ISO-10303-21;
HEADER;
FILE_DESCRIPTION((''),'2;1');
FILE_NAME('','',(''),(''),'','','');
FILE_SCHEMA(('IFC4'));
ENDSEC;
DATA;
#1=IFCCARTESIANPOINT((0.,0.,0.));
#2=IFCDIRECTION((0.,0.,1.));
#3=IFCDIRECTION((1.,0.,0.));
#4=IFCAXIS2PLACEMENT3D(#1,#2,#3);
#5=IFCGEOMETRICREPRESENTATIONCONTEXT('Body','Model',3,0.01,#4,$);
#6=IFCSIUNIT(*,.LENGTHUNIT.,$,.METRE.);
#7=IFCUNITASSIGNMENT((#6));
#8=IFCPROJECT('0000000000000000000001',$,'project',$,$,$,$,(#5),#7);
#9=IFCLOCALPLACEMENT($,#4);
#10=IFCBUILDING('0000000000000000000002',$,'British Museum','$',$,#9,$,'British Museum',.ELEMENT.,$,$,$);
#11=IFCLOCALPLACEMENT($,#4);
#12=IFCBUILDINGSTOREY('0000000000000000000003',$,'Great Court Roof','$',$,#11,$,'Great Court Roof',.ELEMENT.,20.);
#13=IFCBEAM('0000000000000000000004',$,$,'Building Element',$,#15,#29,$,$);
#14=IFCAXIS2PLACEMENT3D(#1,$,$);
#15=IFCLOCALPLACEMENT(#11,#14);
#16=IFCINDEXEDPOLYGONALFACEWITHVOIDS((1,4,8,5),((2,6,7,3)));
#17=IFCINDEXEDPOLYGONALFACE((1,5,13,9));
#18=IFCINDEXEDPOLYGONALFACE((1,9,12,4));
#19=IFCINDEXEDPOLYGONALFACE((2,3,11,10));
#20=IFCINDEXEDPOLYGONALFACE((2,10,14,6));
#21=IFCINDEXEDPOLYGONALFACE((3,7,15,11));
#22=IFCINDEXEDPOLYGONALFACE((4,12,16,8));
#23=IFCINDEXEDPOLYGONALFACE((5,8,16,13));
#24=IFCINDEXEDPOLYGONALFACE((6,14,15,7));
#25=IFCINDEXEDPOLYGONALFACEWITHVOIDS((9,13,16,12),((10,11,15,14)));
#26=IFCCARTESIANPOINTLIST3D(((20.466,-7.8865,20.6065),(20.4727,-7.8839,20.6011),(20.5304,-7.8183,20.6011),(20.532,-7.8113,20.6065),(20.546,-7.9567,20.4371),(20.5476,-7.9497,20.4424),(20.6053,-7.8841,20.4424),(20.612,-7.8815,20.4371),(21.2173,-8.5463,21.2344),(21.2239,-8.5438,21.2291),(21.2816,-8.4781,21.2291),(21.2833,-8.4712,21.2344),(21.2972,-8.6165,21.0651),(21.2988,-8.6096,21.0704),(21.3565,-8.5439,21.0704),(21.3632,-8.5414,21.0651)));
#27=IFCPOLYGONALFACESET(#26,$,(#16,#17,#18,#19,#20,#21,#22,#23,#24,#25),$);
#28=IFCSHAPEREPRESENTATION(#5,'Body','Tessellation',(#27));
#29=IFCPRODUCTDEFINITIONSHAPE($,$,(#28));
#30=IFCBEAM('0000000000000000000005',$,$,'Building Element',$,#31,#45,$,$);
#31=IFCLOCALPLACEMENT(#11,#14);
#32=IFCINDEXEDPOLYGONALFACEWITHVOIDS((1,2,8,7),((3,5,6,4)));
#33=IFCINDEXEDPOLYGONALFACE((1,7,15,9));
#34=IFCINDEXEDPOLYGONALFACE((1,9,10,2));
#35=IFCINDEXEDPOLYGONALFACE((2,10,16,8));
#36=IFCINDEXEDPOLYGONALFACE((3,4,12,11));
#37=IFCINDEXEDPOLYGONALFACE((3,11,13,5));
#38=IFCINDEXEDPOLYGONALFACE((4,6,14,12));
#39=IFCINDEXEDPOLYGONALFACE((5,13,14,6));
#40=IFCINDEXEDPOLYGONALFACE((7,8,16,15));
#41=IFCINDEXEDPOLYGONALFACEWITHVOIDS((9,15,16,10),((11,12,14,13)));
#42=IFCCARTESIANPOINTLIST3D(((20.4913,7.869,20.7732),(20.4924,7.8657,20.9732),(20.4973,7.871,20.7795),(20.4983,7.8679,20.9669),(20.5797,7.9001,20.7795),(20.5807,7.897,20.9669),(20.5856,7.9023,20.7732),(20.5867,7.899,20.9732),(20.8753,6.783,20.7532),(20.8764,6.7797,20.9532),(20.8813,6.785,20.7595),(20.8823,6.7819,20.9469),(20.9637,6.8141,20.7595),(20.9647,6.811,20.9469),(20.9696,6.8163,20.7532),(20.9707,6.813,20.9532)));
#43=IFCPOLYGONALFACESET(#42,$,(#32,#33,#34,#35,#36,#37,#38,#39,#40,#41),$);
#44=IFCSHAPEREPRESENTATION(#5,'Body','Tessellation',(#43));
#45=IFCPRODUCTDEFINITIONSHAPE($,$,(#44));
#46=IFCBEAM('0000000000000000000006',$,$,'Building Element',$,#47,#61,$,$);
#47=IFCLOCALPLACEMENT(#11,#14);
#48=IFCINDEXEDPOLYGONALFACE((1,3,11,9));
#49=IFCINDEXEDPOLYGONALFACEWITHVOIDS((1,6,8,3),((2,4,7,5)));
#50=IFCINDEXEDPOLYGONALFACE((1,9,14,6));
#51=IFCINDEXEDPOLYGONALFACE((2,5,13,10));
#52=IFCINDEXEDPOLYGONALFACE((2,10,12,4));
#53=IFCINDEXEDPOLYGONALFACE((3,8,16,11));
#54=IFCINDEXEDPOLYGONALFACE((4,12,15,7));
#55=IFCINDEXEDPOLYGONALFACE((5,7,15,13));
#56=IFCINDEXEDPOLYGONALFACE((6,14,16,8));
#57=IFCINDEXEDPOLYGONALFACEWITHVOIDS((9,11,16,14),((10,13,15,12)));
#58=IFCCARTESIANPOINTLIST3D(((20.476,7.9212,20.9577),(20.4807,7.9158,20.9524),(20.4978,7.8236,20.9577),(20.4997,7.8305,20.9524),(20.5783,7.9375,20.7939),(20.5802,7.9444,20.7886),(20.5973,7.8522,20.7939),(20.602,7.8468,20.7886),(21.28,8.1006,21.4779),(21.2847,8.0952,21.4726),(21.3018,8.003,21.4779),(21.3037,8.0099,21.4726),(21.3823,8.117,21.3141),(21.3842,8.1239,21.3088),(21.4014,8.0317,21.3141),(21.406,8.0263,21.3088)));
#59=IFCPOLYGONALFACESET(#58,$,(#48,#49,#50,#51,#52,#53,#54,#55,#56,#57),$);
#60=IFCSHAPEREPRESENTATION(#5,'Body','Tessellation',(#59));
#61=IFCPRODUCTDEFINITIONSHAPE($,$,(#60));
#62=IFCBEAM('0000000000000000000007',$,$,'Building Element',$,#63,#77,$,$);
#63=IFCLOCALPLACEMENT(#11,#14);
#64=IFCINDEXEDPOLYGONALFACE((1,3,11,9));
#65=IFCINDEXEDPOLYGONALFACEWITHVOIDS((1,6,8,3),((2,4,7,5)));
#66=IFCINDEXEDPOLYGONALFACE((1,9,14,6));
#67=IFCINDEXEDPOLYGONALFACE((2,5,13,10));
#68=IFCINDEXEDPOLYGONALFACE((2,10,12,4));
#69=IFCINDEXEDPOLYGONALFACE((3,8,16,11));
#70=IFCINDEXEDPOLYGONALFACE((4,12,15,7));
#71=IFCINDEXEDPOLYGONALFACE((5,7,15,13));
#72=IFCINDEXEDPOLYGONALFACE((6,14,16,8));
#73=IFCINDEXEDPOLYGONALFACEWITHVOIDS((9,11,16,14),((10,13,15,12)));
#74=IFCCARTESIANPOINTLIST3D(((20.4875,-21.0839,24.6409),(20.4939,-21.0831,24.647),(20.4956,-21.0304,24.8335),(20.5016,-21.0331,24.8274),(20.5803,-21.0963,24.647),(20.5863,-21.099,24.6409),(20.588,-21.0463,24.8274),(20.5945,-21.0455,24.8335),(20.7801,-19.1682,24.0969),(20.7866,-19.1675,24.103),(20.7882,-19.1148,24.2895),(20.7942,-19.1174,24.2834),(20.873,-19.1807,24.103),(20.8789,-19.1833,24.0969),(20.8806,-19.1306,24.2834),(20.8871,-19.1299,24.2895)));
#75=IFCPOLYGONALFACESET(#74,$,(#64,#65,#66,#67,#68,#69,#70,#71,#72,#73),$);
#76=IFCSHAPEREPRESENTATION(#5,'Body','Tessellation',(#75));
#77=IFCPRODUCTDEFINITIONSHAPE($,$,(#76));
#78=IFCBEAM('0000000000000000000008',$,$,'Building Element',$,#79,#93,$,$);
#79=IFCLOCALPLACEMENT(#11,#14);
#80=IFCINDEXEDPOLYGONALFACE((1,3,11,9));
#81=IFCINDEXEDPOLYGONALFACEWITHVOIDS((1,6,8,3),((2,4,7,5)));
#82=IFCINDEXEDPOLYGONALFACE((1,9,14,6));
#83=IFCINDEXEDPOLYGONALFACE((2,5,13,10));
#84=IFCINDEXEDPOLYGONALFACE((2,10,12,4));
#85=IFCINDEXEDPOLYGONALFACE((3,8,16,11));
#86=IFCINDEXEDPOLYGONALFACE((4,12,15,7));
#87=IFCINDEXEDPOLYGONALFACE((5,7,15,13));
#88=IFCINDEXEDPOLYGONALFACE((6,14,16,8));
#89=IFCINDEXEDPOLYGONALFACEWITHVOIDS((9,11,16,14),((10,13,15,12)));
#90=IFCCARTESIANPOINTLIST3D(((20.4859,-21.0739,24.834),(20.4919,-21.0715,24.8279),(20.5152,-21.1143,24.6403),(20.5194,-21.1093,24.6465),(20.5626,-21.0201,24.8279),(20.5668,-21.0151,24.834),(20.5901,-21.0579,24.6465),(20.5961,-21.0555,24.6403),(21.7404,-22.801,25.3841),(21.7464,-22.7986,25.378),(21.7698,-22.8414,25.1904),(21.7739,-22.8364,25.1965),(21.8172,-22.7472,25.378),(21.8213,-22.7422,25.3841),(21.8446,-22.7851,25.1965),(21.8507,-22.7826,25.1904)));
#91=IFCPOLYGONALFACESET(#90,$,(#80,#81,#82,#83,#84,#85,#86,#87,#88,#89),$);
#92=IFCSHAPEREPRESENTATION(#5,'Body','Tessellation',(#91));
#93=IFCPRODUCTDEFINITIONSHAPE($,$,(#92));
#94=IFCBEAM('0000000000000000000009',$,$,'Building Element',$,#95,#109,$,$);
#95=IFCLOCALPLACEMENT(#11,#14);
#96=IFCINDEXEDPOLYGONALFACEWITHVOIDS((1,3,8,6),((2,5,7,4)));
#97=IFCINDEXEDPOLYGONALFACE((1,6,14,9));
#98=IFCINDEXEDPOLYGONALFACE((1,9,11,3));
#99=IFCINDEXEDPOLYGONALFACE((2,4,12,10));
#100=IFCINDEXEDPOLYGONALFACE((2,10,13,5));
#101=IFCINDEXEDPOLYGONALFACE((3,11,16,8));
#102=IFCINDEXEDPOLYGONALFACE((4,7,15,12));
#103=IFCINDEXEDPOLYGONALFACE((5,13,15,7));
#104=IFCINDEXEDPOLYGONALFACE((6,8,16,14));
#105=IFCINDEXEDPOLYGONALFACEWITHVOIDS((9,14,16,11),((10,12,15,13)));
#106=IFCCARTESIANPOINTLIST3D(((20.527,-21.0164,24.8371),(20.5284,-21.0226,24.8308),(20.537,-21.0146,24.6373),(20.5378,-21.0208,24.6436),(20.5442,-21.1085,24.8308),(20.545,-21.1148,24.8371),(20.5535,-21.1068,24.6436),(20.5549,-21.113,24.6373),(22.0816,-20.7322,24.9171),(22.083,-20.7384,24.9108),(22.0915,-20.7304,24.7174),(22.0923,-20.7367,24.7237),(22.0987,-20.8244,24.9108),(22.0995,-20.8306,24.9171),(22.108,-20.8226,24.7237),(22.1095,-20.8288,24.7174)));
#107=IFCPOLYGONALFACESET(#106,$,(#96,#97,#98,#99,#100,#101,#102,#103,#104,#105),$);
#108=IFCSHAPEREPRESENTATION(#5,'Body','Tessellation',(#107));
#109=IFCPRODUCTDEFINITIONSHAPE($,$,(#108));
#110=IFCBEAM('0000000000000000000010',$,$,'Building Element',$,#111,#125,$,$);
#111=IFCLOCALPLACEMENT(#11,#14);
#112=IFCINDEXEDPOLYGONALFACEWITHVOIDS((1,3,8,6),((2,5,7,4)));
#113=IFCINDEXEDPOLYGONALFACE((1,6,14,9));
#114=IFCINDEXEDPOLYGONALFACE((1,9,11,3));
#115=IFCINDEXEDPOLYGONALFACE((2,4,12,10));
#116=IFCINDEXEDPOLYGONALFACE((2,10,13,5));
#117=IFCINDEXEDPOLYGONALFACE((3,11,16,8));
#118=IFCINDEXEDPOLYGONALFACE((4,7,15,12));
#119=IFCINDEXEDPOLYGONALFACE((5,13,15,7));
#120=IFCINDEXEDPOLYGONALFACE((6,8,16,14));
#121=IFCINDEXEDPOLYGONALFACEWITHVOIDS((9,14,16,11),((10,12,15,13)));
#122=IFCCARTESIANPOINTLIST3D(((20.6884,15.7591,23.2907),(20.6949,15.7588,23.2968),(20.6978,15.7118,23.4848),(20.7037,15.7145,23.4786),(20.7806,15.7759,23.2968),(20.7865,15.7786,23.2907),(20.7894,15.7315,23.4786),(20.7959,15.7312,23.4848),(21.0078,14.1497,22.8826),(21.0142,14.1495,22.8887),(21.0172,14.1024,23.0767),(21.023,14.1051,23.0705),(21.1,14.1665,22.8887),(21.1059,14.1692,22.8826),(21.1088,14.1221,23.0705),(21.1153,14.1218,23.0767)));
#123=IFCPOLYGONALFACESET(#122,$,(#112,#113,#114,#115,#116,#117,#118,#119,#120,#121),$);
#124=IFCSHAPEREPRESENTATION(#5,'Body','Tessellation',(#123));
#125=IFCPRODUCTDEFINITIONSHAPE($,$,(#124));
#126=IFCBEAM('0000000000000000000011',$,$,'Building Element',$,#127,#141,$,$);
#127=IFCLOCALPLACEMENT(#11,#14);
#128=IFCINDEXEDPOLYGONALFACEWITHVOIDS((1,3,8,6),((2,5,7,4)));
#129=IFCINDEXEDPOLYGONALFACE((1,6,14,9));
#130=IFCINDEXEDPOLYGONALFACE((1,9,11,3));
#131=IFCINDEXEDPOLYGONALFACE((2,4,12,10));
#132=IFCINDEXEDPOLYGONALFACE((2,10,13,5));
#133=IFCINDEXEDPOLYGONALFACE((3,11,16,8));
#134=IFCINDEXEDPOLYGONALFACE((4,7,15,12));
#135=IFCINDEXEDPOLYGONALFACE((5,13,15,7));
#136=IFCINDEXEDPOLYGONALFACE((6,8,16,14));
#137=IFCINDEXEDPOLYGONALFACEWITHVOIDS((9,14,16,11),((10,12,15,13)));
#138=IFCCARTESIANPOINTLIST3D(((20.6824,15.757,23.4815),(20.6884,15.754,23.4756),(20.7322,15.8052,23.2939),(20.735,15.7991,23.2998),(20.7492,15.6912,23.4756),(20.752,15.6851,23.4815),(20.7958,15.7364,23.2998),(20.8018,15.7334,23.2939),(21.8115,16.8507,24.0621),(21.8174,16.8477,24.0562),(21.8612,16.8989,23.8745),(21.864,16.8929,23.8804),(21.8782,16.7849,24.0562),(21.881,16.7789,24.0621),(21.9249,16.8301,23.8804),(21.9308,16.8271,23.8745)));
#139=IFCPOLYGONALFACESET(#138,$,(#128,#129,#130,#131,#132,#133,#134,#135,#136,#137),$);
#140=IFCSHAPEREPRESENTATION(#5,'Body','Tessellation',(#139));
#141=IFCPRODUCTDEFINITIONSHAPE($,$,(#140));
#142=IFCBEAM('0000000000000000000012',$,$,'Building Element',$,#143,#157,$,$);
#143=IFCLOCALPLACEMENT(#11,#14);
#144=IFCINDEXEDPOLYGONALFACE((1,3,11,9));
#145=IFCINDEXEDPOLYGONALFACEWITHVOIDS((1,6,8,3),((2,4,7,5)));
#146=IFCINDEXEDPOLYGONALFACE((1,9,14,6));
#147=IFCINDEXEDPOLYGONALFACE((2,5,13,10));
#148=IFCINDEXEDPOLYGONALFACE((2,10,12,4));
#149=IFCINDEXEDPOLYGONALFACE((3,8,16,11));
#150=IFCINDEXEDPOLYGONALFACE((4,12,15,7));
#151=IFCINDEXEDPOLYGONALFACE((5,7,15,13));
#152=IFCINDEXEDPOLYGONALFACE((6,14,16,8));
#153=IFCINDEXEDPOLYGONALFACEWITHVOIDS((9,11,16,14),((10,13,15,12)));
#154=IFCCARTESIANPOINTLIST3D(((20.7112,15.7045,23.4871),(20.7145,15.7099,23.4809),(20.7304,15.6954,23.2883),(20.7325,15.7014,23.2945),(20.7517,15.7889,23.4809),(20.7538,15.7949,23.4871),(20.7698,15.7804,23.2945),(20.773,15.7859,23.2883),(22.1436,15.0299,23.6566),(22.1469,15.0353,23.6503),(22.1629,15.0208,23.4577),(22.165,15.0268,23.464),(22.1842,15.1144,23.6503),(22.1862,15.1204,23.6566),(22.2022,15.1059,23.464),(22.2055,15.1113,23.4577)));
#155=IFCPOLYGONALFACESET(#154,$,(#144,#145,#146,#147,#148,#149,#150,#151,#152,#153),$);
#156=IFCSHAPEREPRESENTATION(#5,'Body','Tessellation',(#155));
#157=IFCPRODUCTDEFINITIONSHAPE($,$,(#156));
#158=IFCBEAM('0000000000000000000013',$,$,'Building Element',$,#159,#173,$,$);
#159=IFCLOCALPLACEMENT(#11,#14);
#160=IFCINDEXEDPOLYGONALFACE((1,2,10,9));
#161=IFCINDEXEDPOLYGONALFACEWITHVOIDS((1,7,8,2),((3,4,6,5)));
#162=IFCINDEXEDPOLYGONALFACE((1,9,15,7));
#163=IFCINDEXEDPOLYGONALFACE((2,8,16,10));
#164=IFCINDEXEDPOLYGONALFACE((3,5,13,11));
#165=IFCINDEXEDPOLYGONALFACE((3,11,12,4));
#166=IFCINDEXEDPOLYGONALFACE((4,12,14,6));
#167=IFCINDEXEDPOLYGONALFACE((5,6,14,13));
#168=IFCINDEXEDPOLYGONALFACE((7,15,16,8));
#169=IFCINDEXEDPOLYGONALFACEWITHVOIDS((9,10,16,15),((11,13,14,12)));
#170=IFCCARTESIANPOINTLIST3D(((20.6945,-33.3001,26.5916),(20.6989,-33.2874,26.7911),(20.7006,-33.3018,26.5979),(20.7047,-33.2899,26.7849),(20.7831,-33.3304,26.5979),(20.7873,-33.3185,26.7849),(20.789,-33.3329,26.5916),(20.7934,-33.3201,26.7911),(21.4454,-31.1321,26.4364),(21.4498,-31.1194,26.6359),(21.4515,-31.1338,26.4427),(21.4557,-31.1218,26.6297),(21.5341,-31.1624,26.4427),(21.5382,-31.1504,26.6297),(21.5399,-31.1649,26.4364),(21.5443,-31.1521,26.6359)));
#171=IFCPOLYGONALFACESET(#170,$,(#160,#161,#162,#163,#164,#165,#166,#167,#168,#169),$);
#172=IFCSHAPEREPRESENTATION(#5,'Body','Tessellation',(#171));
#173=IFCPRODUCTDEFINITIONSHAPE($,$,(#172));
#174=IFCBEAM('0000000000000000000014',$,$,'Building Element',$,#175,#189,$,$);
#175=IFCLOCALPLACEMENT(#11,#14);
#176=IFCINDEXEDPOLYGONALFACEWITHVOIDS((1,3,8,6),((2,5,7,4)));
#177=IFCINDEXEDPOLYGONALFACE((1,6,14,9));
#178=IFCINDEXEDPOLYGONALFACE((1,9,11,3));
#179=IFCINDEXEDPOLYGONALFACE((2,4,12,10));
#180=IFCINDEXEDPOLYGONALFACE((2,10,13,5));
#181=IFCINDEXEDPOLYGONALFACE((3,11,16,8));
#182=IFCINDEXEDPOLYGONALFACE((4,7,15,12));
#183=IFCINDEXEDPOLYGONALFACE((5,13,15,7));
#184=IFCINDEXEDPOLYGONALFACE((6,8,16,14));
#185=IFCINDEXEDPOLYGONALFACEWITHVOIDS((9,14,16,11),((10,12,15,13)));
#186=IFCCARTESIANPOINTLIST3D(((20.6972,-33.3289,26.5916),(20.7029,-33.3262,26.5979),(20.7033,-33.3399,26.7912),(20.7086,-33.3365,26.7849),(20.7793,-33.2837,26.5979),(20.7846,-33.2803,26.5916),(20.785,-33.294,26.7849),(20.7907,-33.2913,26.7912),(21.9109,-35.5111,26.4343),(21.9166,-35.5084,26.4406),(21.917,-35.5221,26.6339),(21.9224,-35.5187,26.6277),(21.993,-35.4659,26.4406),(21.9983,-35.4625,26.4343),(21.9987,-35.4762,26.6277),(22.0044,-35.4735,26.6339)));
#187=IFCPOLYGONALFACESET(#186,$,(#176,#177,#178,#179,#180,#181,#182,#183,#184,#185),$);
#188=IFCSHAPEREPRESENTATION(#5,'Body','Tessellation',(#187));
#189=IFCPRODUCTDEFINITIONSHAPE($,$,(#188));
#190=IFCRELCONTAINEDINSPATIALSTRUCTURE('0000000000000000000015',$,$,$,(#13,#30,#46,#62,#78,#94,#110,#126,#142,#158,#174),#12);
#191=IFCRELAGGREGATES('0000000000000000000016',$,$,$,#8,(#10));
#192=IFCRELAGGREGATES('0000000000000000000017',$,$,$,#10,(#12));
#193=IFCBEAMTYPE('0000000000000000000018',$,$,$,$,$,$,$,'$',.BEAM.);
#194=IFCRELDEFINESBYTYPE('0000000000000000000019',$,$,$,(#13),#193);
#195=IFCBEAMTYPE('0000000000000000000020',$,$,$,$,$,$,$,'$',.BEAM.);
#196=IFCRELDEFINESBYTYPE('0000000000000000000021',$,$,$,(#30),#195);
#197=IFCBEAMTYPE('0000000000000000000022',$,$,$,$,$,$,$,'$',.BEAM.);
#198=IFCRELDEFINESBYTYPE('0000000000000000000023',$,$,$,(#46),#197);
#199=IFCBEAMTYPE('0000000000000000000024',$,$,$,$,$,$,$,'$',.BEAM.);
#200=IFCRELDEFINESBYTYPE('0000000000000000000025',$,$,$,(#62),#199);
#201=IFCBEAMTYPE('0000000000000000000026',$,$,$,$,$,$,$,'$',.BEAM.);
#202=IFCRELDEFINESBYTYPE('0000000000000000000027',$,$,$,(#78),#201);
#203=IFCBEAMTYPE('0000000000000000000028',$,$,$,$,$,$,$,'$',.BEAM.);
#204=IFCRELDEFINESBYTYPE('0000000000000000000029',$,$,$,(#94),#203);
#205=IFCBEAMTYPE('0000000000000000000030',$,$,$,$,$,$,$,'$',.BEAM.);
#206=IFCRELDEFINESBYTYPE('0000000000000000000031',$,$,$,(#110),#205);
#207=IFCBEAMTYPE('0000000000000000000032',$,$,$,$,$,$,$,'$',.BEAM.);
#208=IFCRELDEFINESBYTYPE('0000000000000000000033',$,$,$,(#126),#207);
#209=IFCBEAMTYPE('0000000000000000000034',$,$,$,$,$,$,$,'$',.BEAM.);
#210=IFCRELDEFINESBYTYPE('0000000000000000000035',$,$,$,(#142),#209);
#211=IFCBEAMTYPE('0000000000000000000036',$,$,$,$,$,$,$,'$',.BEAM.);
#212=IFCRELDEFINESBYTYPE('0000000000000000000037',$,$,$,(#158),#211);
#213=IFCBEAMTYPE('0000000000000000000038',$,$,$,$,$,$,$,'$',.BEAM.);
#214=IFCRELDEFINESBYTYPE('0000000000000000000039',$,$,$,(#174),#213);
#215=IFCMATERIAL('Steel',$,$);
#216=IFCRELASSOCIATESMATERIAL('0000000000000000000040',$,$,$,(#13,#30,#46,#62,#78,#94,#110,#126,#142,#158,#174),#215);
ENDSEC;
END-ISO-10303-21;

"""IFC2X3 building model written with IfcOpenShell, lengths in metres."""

from ifc_helpers import new_model, si_unit, frame, origin_with_axes, origin_2d, place, context, project, spatial, hollow_rectangle, extrude, material, type_object, element, save


model = new_model("IFC2X3")

# Units and contexts
model_context = context("Model", 3, precision=0.01, world=origin_with_axes(), identifier="Body")
ifc_project = project(units=[si_unit("LENGTHUNIT", "METRE")], contexts=[model_context])

# Building, storey
building_placement = place(None, origin_with_axes())
building = spatial("IfcBuilding", under=ifc_project, at=building_placement, Name="British Museum", Description="$", LongName="British Museum", CompositionType="ELEMENT")
storey_placement = place(None, origin_with_axes())
storey = spatial("IfcBuildingStorey", under=building, at=storey_placement, Name="Great Court Roof", Description="$", LongName="Great Court Roof", CompositionType="ELEMENT", Elevation=20.0)

# Beams
ifc_material = material(Name="Steel")
beam_type_1 = type_object("IfcBeamType", ElementType="$", PredefinedType="BEAM")
beam_1_placement = place(None, origin_with_axes())
element("IfcBeam", 1, at=beam_1_placement, inside=storey, type_object=beam_type_1, material=ifc_material, Description="Building Element", context=model_context, shape_type="SweptSolid", body=[
    extrude(hollow_rectangle(XDim=0.1, YDim=0.2, WallThickness=0.0063, InnerFilletRadius=0.0, OuterFilletRadius=0.0, at=origin_2d()), frame((20.539, -7.884, 20.5218), z_axis=(0.63625, -0.558852, 0.531855), x_axis=(0.65993, 0.751327, 0.0)), (0.0, 0.0, 1.0), 1.1807),
])
beam_type_2 = type_object("IfcBeamType", ElementType="$", PredefinedType="BEAM")
beam_2_placement = place(None, origin_with_axes())
element("IfcBeam", 2, at=beam_2_placement, inside=storey, type_object=beam_type_2, material=ifc_material, Description="Building Element", context=model_context, shape_type="SweptSolid", body=[
    extrude(hollow_rectangle(XDim=0.1, YDim=0.2, WallThickness=0.0063, InnerFilletRadius=0.0, OuterFilletRadius=0.0, at=origin_2d()), frame((20.539, 7.884, 20.8732), z_axis=(0.333315, -0.942656, -0.017338), x_axis=(0.942798, 0.333365, 0.0)), (0.0, 0.0, 1.0), 1.1521),
])
beam_type_3 = type_object("IfcBeamType", ElementType="$", PredefinedType="BEAM")
beam_3_placement = place(None, origin_with_axes())
element("IfcBeam", 3, at=beam_3_placement, inside=storey, type_object=beam_type_3, material=ifc_material, Description="Building Element", context=model_context, shape_type="SweptSolid", body=[
    extrude(hollow_rectangle(XDim=0.1, YDim=0.2, WallThickness=0.0063, InnerFilletRadius=0.0, OuterFilletRadius=0.0, at=origin_2d()), frame((20.539, 7.884, 20.8732), z_axis=(0.825235, 0.18417, 0.533918), x_axis=(-0.217814, 0.97599, 0.0)), (0.0, 0.0, 1.0), 0.9743),
])
beam_type_4 = type_object("IfcBeamType", ElementType="$", PredefinedType="BEAM")
beam_4_placement = place(None, origin_with_axes())
element("IfcBeam", 4, at=beam_4_placement, inside=storey, type_object=beam_type_4, material=ifc_material, Description="Building Element", context=model_context, shape_type="SweptSolid", body=[
    extrude(hollow_rectangle(XDim=0.1, YDim=0.2, WallThickness=0.0063, InnerFilletRadius=0.0, OuterFilletRadius=0.0, at=origin_2d()), frame((20.541, -21.0647, 24.7372), z_axis=(0.145382, 0.951744, -0.270274), x_axis=(-0.988533, 0.151002, 0.0)), (0.0, 0.0, 1.0), 2.0127),
])
beam_type_5 = type_object("IfcBeamType", ElementType="$", PredefinedType="BEAM")
beam_5_placement = place(None, origin_with_axes())
element("IfcBeam", 5, at=beam_5_placement, inside=storey, type_object=beam_type_5, material=ifc_material, Description="Building Element", context=model_context, shape_type="SweptSolid", body=[
    extrude(hollow_rectangle(XDim=0.1, YDim=0.2, WallThickness=0.0063, InnerFilletRadius=0.0, OuterFilletRadius=0.0, at=origin_2d()), frame((20.541, -21.0647, 24.7372), z_axis=(0.569112, -0.783482, 0.249536), x_axis=(0.809076, 0.587704, 0.0)), (0.0, 0.0, 1.0), 2.2044),
])
beam_type_6 = type_object("IfcBeamType", ElementType="$", PredefinedType="BEAM")
beam_6_placement = place(None, origin_with_axes())
element("IfcBeam", 6, at=beam_6_placement, inside=storey, type_object=beam_type_6, material=ifc_material, Description="Building Element", context=model_context, shape_type="SweptSolid", body=[
    extrude(hollow_rectangle(XDim=0.1, YDim=0.2, WallThickness=0.0063, InnerFilletRadius=0.0, OuterFilletRadius=0.0, at=origin_2d()), frame((20.541, -21.0647, 24.7372), z_axis=(0.982439, 0.179593, 0.0506), x_axis=(-0.179823, 0.983699, 0.0)), (0.0, 0.0, 1.0), 1.5823),
])
beam_type_7 = type_object("IfcBeamType", ElementType="$", PredefinedType="BEAM")
beam_7_placement = place(None, origin_with_axes())
element("IfcBeam", 7, at=beam_7_placement, inside=storey, type_object=beam_type_7, material=ifc_material, Description="Building Element", context=model_context, shape_type="SweptSolid", body=[
    extrude(hollow_rectangle(XDim=0.1, YDim=0.2, WallThickness=0.0063, InnerFilletRadius=0.0, OuterFilletRadius=0.0, at=origin_2d()), frame((20.7421, 15.7452, 23.3877), z_axis=(0.188904, -0.951869, -0.241372), x_axis=(0.980871, 0.194659, 0.0)), (0.0, 0.0, 1.0), 1.6908),
])
beam_type_8 = type_object("IfcBeamType", ElementType="$", PredefinedType="BEAM")
beam_8_placement = place(None, origin_with_axes())
element("IfcBeam", 8, at=beam_8_placement, inside=storey, type_object=beam_type_8, material=ifc_material, Description="Building Element", context=model_context, shape_type="SweptSolid", body=[
    extrude(hollow_rectangle(XDim=0.1, YDim=0.2, WallThickness=0.0063, InnerFilletRadius=0.0, OuterFilletRadius=0.0, at=origin_2d()), frame((20.7421, 15.7452, 23.3877), z_axis=(0.673754, 0.652701, 0.346464), x_axis=(-0.695796, 0.718239, 0.0)), (0.0, 0.0, 1.0), 1.6757),
])
beam_type_9 = type_object("IfcBeamType", ElementType="$", PredefinedType="BEAM")
beam_9_placement = place(None, origin_with_axes())
element("IfcBeam", 9, at=beam_9_placement, inside=storey, type_object=beam_type_9, material=ifc_material, Description="Building Element", context=model_context, shape_type="SweptSolid", body=[
    extrude(hollow_rectangle(XDim=0.1, YDim=0.2, WallThickness=0.0063, InnerFilletRadius=0.0, OuterFilletRadius=0.0, at=origin_2d()), frame((20.7421, 15.7452, 23.3877), z_axis=(0.89957, -0.42362, 0.106398), x_axis=(0.426039, 0.904705, 0.0)), (0.0, 0.0, 1.0), 1.5924),
])
beam_type_10 = type_object("IfcBeamType", ElementType="$", PredefinedType="BEAM")
beam_10_placement = place(None, origin_with_axes())
element("IfcBeam", 10, at=beam_10_placement, inside=storey, type_object=beam_type_10, material=ifc_material, Description="Building Element", context=model_context, shape_type="SweptSolid", body=[
    extrude(hollow_rectangle(XDim=0.1, YDim=0.2, WallThickness=0.0063, InnerFilletRadius=0.0, OuterFilletRadius=0.0, at=origin_2d()), frame((20.7439, -33.3101, 26.6914), z_axis=(0.326554, 0.942766, -0.067491), x_axis=(-0.944921, 0.3273, 0.0)), (0.0, 0.0, 1.0), 2.2996),
])
beam_type_11 = type_object("IfcBeamType", ElementType="$", PredefinedType="BEAM")
beam_11_placement = place(None, origin_with_axes())
element("IfcBeam", 11, at=beam_11_placement, inside=storey, type_object=beam_type_11, material=ifc_material, Description="Building Element", context=model_context, shape_type="SweptSolid", body=[
    extrude(hollow_rectangle(XDim=0.1, YDim=0.2, WallThickness=0.0063, InnerFilletRadius=0.0, OuterFilletRadius=0.0, at=origin_2d()), frame((20.7439, -33.3101, 26.6914), z_axis=(0.48512, -0.872187, -0.062845), x_axis=(0.873914, 0.48608, 0.0)), (0.0, 0.0, 1.0), 2.502),
])

save(model, "model.ifc")
